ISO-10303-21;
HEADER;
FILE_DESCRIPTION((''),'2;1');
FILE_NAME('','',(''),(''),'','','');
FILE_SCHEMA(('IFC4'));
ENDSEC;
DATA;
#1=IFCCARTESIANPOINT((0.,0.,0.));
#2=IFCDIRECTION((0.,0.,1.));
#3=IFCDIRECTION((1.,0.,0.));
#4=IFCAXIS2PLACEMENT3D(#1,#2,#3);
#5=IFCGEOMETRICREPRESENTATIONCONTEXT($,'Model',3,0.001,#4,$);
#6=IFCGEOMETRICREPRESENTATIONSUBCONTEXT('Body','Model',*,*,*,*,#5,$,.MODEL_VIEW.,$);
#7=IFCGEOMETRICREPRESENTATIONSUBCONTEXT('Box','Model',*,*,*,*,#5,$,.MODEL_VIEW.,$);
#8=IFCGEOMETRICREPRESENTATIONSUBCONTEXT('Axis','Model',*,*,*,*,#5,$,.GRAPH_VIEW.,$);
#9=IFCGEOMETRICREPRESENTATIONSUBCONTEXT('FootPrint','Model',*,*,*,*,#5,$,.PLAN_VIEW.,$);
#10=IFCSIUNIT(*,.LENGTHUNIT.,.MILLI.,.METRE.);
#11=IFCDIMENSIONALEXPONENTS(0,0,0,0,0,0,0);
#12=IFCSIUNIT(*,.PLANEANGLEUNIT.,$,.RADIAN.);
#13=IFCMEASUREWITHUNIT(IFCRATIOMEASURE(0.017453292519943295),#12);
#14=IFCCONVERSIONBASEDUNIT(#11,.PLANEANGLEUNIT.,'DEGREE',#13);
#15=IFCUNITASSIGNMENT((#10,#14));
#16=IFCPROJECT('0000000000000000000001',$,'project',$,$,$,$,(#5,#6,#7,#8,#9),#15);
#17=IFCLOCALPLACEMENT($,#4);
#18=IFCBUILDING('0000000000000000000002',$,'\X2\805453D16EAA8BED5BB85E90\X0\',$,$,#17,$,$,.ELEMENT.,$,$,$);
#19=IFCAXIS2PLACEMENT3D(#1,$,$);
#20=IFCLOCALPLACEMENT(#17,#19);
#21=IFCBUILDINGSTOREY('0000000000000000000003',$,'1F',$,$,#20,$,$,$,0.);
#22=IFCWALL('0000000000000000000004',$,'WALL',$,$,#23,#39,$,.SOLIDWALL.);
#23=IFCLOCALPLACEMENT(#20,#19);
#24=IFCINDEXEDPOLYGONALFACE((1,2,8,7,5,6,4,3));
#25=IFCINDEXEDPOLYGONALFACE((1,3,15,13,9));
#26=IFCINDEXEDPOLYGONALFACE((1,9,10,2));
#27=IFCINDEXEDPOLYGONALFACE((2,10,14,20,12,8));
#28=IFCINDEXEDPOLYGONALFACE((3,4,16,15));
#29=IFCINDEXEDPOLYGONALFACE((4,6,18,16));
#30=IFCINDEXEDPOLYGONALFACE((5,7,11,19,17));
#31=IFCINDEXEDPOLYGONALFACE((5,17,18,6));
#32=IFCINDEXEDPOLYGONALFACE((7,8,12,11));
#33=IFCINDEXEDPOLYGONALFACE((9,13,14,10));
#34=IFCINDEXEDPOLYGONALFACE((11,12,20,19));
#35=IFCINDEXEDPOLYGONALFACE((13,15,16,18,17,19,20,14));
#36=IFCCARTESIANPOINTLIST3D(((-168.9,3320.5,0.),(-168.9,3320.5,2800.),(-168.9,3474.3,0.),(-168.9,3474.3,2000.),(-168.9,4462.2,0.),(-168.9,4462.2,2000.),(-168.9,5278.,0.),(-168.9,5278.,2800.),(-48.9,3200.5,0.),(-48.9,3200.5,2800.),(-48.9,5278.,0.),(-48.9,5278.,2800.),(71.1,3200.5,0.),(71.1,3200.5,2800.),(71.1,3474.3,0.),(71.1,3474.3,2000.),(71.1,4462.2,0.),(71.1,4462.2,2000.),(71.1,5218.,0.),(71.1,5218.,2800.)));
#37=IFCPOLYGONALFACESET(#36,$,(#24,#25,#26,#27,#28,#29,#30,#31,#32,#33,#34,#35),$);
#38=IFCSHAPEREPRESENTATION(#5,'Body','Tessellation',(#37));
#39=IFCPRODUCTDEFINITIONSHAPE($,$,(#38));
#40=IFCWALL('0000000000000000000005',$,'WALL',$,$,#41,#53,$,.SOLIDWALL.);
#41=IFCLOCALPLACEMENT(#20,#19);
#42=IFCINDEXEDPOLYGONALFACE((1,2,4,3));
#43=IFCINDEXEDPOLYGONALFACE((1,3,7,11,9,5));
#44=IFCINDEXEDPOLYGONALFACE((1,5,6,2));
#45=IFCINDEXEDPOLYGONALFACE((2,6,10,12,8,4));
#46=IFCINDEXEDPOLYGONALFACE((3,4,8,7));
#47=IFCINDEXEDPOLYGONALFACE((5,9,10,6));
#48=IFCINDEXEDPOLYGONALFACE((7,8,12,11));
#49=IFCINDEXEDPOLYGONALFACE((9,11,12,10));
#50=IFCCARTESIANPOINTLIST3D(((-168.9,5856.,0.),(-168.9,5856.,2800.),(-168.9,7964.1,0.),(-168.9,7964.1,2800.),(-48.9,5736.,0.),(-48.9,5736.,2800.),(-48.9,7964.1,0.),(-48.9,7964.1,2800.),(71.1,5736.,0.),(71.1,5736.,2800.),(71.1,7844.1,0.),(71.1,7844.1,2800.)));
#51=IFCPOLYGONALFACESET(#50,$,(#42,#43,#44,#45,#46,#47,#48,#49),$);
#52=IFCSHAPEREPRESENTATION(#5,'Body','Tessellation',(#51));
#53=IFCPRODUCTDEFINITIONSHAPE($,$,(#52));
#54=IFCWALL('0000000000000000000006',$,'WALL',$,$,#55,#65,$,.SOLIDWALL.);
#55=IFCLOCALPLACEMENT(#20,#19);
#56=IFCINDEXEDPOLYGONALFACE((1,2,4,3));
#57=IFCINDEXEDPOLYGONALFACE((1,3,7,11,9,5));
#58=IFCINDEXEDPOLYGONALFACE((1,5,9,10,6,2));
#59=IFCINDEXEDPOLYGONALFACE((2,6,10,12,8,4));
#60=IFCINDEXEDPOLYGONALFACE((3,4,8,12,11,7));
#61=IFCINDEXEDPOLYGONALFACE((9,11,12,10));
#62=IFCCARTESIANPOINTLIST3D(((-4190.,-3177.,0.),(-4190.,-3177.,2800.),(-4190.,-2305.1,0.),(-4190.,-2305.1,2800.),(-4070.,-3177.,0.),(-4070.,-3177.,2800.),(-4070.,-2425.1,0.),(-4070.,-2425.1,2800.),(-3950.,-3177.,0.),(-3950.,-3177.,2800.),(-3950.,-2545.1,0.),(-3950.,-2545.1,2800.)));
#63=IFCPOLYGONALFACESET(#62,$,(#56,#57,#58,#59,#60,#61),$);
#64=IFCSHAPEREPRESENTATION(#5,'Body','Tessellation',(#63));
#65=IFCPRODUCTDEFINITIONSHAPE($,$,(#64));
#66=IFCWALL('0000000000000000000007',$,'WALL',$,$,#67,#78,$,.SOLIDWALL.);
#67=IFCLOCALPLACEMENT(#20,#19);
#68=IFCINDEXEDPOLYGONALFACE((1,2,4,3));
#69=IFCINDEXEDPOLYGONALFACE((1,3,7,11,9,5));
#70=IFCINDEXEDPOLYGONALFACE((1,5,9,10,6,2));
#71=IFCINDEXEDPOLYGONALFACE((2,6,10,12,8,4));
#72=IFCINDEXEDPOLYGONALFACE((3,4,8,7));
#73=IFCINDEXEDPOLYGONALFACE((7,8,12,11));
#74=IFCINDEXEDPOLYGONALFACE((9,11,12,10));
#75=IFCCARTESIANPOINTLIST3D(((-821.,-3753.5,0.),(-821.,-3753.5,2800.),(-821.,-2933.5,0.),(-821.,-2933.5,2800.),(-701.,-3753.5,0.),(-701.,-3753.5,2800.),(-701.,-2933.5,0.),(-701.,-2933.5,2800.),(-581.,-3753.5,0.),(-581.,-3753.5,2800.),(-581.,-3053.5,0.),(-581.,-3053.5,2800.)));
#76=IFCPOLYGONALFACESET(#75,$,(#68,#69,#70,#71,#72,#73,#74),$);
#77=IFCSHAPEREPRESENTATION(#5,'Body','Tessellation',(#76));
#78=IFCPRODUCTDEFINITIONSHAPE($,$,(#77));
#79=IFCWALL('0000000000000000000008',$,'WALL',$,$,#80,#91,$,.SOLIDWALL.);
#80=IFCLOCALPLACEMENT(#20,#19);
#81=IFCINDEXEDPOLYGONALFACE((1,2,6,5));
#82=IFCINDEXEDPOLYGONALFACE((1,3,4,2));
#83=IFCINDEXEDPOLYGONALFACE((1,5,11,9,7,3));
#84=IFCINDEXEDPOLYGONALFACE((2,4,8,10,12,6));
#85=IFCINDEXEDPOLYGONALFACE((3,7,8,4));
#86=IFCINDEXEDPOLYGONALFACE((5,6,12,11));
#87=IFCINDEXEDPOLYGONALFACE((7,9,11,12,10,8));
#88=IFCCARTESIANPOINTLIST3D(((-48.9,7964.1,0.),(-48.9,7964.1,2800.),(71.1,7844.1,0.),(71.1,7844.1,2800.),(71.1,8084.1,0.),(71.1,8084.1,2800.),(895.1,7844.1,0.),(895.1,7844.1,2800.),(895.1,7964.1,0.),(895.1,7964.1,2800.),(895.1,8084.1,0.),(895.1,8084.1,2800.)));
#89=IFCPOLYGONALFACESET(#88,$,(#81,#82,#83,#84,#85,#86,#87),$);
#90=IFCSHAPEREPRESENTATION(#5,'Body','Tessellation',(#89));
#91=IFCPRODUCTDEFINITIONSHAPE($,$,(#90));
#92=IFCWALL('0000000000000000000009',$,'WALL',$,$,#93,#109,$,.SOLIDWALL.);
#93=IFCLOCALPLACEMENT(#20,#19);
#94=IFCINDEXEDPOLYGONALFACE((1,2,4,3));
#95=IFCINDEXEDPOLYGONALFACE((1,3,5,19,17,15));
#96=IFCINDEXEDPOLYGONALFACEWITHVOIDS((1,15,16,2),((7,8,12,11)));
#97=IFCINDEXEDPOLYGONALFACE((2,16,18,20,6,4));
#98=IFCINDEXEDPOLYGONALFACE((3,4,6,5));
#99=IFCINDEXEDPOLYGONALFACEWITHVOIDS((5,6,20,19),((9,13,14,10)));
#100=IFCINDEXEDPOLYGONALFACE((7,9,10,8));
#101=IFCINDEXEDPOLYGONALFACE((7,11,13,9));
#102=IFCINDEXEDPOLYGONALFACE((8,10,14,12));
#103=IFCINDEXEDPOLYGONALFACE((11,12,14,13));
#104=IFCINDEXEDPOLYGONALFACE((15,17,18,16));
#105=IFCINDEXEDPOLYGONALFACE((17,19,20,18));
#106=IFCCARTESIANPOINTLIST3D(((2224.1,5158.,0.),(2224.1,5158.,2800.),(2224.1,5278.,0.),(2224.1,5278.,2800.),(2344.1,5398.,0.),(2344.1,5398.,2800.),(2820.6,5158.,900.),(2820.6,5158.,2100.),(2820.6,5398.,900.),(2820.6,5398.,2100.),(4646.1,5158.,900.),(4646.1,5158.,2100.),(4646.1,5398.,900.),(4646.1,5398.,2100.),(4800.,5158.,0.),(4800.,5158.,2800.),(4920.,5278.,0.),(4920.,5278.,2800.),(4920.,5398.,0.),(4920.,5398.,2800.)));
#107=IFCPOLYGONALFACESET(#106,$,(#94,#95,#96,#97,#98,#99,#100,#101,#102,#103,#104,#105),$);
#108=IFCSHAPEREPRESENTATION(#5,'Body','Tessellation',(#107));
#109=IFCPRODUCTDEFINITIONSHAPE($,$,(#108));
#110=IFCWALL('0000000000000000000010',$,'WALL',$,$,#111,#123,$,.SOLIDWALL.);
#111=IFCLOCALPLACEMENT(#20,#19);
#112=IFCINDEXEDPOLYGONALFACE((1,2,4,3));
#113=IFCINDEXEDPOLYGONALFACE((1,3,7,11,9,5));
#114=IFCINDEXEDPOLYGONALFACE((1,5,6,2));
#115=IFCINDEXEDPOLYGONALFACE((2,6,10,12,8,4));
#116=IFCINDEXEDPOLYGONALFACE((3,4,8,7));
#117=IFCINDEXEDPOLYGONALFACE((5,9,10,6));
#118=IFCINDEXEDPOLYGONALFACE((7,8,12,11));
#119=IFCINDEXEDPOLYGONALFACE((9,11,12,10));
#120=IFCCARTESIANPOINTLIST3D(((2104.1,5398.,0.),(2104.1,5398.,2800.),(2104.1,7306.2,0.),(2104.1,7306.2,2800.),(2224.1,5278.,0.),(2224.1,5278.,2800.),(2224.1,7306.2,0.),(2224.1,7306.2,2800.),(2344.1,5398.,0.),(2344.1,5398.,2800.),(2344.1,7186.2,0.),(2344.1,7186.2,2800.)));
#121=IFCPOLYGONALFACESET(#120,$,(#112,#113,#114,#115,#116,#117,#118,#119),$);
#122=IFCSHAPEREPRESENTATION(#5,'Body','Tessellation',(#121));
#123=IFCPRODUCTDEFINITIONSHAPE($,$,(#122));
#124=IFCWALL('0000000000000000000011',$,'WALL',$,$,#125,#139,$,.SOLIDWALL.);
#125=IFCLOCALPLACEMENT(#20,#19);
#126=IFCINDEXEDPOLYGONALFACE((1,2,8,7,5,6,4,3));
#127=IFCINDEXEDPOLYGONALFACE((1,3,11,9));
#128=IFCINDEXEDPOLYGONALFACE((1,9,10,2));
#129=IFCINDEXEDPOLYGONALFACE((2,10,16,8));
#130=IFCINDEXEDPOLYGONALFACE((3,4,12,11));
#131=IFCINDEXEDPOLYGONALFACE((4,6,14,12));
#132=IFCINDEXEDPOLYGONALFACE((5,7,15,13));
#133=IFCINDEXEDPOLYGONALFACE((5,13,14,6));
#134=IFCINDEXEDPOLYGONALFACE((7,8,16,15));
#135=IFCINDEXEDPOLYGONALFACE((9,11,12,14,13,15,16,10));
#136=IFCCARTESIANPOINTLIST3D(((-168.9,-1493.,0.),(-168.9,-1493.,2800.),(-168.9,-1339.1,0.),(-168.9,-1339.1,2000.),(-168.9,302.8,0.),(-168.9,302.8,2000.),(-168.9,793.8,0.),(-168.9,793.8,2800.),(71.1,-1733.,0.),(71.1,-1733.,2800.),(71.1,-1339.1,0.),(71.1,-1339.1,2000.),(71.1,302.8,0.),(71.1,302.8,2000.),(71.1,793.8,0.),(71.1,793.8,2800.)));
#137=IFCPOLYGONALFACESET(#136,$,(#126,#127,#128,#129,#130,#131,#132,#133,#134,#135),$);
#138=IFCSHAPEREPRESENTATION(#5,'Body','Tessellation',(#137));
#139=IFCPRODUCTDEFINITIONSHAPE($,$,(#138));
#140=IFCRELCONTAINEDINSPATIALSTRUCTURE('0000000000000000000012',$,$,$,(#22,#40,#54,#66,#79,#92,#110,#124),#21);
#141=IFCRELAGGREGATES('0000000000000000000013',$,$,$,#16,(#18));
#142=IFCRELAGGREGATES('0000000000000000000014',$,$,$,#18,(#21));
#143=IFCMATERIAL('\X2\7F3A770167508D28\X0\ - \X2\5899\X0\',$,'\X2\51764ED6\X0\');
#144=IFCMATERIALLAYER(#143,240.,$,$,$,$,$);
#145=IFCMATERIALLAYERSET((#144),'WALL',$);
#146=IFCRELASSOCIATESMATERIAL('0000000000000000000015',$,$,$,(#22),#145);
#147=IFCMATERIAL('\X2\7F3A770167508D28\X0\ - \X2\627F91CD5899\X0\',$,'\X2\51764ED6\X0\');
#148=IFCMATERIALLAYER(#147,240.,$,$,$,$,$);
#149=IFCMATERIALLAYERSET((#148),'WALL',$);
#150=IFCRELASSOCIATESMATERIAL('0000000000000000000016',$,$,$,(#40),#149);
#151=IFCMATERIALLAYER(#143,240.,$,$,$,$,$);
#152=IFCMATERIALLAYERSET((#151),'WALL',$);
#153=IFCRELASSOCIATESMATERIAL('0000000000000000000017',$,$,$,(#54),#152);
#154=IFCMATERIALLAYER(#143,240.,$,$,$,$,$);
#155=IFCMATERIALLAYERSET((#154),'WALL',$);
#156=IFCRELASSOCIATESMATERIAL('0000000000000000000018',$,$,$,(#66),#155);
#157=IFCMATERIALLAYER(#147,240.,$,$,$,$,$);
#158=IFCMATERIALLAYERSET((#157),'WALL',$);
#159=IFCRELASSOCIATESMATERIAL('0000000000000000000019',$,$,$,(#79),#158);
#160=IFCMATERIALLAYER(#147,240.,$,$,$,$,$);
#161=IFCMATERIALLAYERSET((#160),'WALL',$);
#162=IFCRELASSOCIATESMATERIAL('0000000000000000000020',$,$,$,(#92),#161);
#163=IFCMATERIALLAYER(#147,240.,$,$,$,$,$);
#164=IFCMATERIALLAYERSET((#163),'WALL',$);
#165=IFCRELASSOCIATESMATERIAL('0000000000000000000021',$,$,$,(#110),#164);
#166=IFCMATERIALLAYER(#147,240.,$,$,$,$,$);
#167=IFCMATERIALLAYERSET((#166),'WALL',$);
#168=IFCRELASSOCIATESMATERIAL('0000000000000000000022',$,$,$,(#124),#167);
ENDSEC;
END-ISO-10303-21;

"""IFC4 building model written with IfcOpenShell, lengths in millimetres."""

from ifc_helpers import new_model, entity, si_unit, converted_unit, frame, origin, origin_with_axes, place, context, subcontext, project, spatial, polyline, segment, composite_curve, outline, extrude, material, layer, layer_set, layer_usage, element, save


model = new_model("IFC4")

# Units and contexts
model_context = context("Model", 3, precision=0.001, world=origin_with_axes())
body_context = subcontext(model_context, "Body", "Model", "MODEL_VIEW")
box_context = subcontext(model_context, "Box", "Model", "MODEL_VIEW")
axis_context = subcontext(model_context, "Axis", "Model", "GRAPH_VIEW")
footprint_context = subcontext(model_context, "FootPrint", "Model", "PLAN_VIEW")
ifc_project = project(units=[si_unit("LENGTHUNIT", "METRE", prefix="MILLI"), converted_unit("PLANEANGLEUNIT", "DEGREE", entity("IfcRatioMeasure", 0.017453292519943295), si_unit("PLANEANGLEUNIT", "RADIAN"), dimensions=[0, 0, 0, 0, 0, 0, 0])], contexts=[model_context, body_context, box_context, axis_context, footprint_context])

# Building, storey
building_placement = place(None, origin_with_axes())
building = spatial("IfcBuilding", under=ifc_project, at=building_placement, Name="联发溪语宸庐", CompositionType="ELEMENT")
storey_placement = place(building_placement, origin())
storey = spatial("IfcBuildingStorey", under=building, at=storey_placement, Name="1F", Elevation=0.0)

# Shared definitions
ifc_material_1 = material(Name="缺省材质 - 墙", Category="其他")

# Shared definitions
ifc_material_2 = material(Name="缺省材质 - 承重墙", Category="其他")

# Wall, opening
ifc_layer_1 = layer(ifc_material_1, 240.0)
ifc_layer_set_1 = layer_set([ifc_layer_1], Name="WALL")
ifc_layer_usage_1 = layer_usage(ifc_layer_set_1, "AXIS2", "NEGATIVE", 120.0)
wall_1_placement = place(None, origin_with_axes())
wall_1 = element("IfcWall", 1, at=wall_1_placement, inside=storey, material=ifc_layer_usage_1, Name="WALL", PredefinedType="SOLIDWALL", context=model_context, shape_type="SweptSolid", body=[
    extrude(outline(composite_curve([segment(polyline([(-48.9, 3200.5), (71.1, 3200.5)]), True, "CONTINUOUS"), segment(polyline([(71.1, 3200.5), (71.1, 5218.0)]), True, "CONTINUOUS"), segment(polyline([(71.1, 5218.0), (-48.9, 5278.0)]), True, "CONTINUOUS"), segment(polyline([(-48.9, 5278.0), (-168.9, 5278.0)]), True, "CONTINUOUS"), segment(polyline([(-168.9, 5278.0), (-168.9, 3320.5)]), True, "CONTINUOUS"), segment(polyline([(-168.9, 3320.5), (-48.9, 3200.5)]), True, "CONTINUOUS")], self_intersect=False)), origin(), (0.0, 0.0, 1.0), 2800.0),
])
opening_1_placement = place(None, origin_with_axes())
element("IfcOpeningElement", 2, at=opening_1_placement, cuts=wall_1, ObjectType="OPENING", PredefinedType="OPENING", context=model_context, shape_type="SweptSolid", body=[
    extrude(outline(composite_curve([segment(polyline([(-168.9, 4462.2), (-168.9, 3474.3)]), True, "CONTINUOUS"), segment(polyline([(-168.9, 3474.3), (71.1, 3474.3)]), True, "CONTINUOUS"), segment(polyline([(71.1, 3474.3), (71.1, 4462.2)]), True, "CONTINUOUS"), segment(polyline([(71.1, 4462.2), (-168.9, 4462.2)]), True, "CONTINUOUS")], self_intersect=False)), origin_with_axes(), (0.0, 0.0, 1.0), 2000.0),
])

# Walls
ifc_layer_2 = layer(ifc_material_2, 240.0)
ifc_layer_set_2 = layer_set([ifc_layer_2], Name="WALL")
ifc_layer_usage_2 = layer_usage(ifc_layer_set_2, "AXIS2", "NEGATIVE", 120.0)
wall_2_placement = place(None, origin_with_axes())
element("IfcWall", 3, at=wall_2_placement, inside=storey, material=ifc_layer_usage_2, Name="WALL", PredefinedType="SOLIDWALL", context=model_context, shape_type="SweptSolid", body=[
    extrude(outline(composite_curve([segment(polyline([(-48.9, 5736.0), (71.1, 5736.0)]), True, "CONTINUOUS"), segment(polyline([(71.1, 5736.0), (71.1, 7844.1)]), True, "CONTINUOUS"), segment(polyline([(71.1, 7844.1), (-48.9, 7964.1)]), True, "CONTINUOUS"), segment(polyline([(-48.9, 7964.1), (-168.9, 7964.1)]), True, "CONTINUOUS"), segment(polyline([(-168.9, 7964.1), (-168.9, 5856.0)]), True, "CONTINUOUS"), segment(polyline([(-168.9, 5856.0), (-48.9, 5736.0)]), True, "CONTINUOUS")], self_intersect=False)), origin(), (0.0, 0.0, 1.0), 2800.0),
])
ifc_layer_3 = layer(ifc_material_1, 240.0)
ifc_layer_set_3 = layer_set([ifc_layer_3], Name="WALL")
ifc_layer_usage_3 = layer_usage(ifc_layer_set_3, "AXIS2", "NEGATIVE", 120.0)
wall_3_placement = place(None, origin_with_axes())
element("IfcWall", 4, at=wall_3_placement, inside=storey, material=ifc_layer_usage_3, Name="WALL", PredefinedType="SOLIDWALL", context=model_context, shape_type="SweptSolid", body=[
    extrude(outline(composite_curve([segment(polyline([(-4070.0, -2425.1), (-4190.0, -2305.1)]), True, "CONTINUOUS"), segment(polyline([(-4190.0, -2305.1), (-4190.0, -3177.0)]), True, "CONTINUOUS"), segment(polyline([(-4190.0, -3177.0), (-4070.0, -3177.0)]), True, "CONTINUOUS"), segment(polyline([(-4070.0, -3177.0), (-3950.0, -3177.0)]), True, "CONTINUOUS"), segment(polyline([(-3950.0, -3177.0), (-3950.0, -2545.1)]), True, "CONTINUOUS"), segment(polyline([(-3950.0, -2545.1), (-4070.0, -2425.1)]), True, "CONTINUOUS")], self_intersect=False)), origin(), (0.0, 0.0, 1.0), 2800.0),
])
ifc_layer_4 = layer(ifc_material_1, 240.0)
ifc_layer_set_4 = layer_set([ifc_layer_4], Name="WALL")
ifc_layer_usage_4 = layer_usage(ifc_layer_set_4, "AXIS2", "NEGATIVE", 120.0)
wall_4_placement = place(None, origin_with_axes())
element("IfcWall", 5, at=wall_4_placement, inside=storey, material=ifc_layer_usage_4, Name="WALL", PredefinedType="SOLIDWALL", context=model_context, shape_type="SweptSolid", body=[
    extrude(outline(composite_curve([segment(polyline([(-701.0, -3753.5), (-581.0, -3753.5)]), True, "CONTINUOUS"), segment(polyline([(-581.0, -3753.5), (-581.0, -3053.5)]), True, "CONTINUOUS"), segment(polyline([(-581.0, -3053.5), (-701.0, -2933.5)]), True, "CONTINUOUS"), segment(polyline([(-701.0, -2933.5), (-821.0, -2933.5)]), True, "CONTINUOUS"), segment(polyline([(-821.0, -2933.5), (-821.0, -3753.5)]), True, "CONTINUOUS"), segment(polyline([(-821.0, -3753.5), (-701.0, -3753.5)]), True, "CONTINUOUS")], self_intersect=False)), origin(), (0.0, 0.0, 1.0), 2800.0),
])
ifc_layer_5 = layer(ifc_material_2, 240.0)
ifc_layer_set_5 = layer_set([ifc_layer_5], Name="WALL")
ifc_layer_usage_5 = layer_usage(ifc_layer_set_5, "AXIS2", "NEGATIVE", 120.0)
wall_5_placement = place(None, origin_with_axes())
element("IfcWall", 6, at=wall_5_placement, inside=storey, material=ifc_layer_usage_5, Name="WALL", PredefinedType="SOLIDWALL", context=model_context, shape_type="SweptSolid", body=[
    extrude(outline(composite_curve([segment(polyline([(-48.9, 7964.1), (71.1, 7844.1)]), True, "CONTINUOUS"), segment(polyline([(71.1, 7844.1), (895.1, 7844.1)]), True, "CONTINUOUS"), segment(polyline([(895.1, 7844.1), (895.1, 7964.1)]), True, "CONTINUOUS"), segment(polyline([(895.1, 7964.1), (895.1, 8084.1)]), True, "CONTINUOUS"), segment(polyline([(895.1, 8084.1), (71.1, 8084.1)]), True, "CONTINUOUS"), segment(polyline([(71.1, 8084.1), (-48.9, 7964.1)]), True, "CONTINUOUS")], self_intersect=False)), origin(), (0.0, 0.0, 1.0), 2800.0),
])

# Wall, opening
ifc_layer_6 = layer(ifc_material_2, 240.0)
ifc_layer_set_6 = layer_set([ifc_layer_6], Name="WALL")
ifc_layer_usage_6 = layer_usage(ifc_layer_set_6, "AXIS2", "NEGATIVE", 120.0)
wall_6_placement = place(None, origin_with_axes())
wall_6 = element("IfcWall", 7, at=wall_6_placement, inside=storey, material=ifc_layer_usage_6, Name="WALL", PredefinedType="SOLIDWALL", context=model_context, shape_type="SweptSolid", body=[
    extrude(outline(composite_curve([segment(polyline([(2224.1, 5278.0), (2224.1, 5158.0)]), True, "CONTINUOUS"), segment(polyline([(2224.1, 5158.0), (4800.0, 5158.0)]), True, "CONTINUOUS"), segment(polyline([(4800.0, 5158.0), (4920.0, 5278.0)]), True, "CONTINUOUS"), segment(polyline([(4920.0, 5278.0), (4920.0, 5398.0)]), True, "CONTINUOUS"), segment(polyline([(4920.0, 5398.0), (2344.1, 5398.0)]), True, "CONTINUOUS"), segment(polyline([(2344.1, 5398.0), (2224.1, 5278.0)]), True, "CONTINUOUS")], self_intersect=False)), origin(), (0.0, 0.0, 1.0), 2800.0),
])
opening_2_placement = place(None, origin_with_axes())
element("IfcOpeningElement", 8, at=opening_2_placement, cuts=wall_6, ObjectType="OPENING", PredefinedType="OPENING", context=model_context, shape_type="SweptSolid", body=[
    extrude(outline(composite_curve([segment(polyline([(4646.1, 5398.0), (2820.6, 5398.0)]), True, "CONTINUOUS"), segment(polyline([(2820.6, 5398.0), (2820.6, 5158.0)]), True, "CONTINUOUS"), segment(polyline([(2820.6, 5158.0), (4646.1, 5158.0)]), True, "CONTINUOUS"), segment(polyline([(4646.1, 5158.0), (4646.1, 5398.0)]), True, "CONTINUOUS")], self_intersect=False)), frame((0.0, 0.0, 900.0), z_axis=(0.0, 0.0, 1.0), x_axis=(1.0, 0.0, 0.0)), (0.0, 0.0, 1.0), 1200.0),
])

# Wall
ifc_layer_7 = layer(ifc_material_2, 240.0)
ifc_layer_set_7 = layer_set([ifc_layer_7], Name="WALL")
ifc_layer_usage_7 = layer_usage(ifc_layer_set_7, "AXIS2", "NEGATIVE", 120.0)
wall_7_placement = place(None, origin_with_axes())
element("IfcWall", 9, at=wall_7_placement, inside=storey, material=ifc_layer_usage_7, Name="WALL", PredefinedType="SOLIDWALL", context=model_context, shape_type="SweptSolid", body=[
    extrude(outline(composite_curve([segment(polyline([(2224.1, 7306.2), (2104.1, 7306.2)]), True, "CONTINUOUS"), segment(polyline([(2104.1, 7306.2), (2104.1, 5398.0)]), True, "CONTINUOUS"), segment(polyline([(2104.1, 5398.0), (2224.1, 5278.0)]), True, "CONTINUOUS"), segment(polyline([(2224.1, 5278.0), (2344.1, 5398.0)]), True, "CONTINUOUS"), segment(polyline([(2344.1, 5398.0), (2344.1, 7186.2)]), True, "CONTINUOUS"), segment(polyline([(2344.1, 7186.2), (2224.1, 7306.2)]), True, "CONTINUOUS")], self_intersect=False)), origin(), (0.0, 0.0, 1.0), 2800.0),
])

# Wall, opening
ifc_layer_8 = layer(ifc_material_2, 240.0)
ifc_layer_set_8 = layer_set([ifc_layer_8], Name="WALL")
ifc_layer_usage_8 = layer_usage(ifc_layer_set_8, "AXIS2", "NEGATIVE", 120.0)
wall_8_placement = place(None, origin_with_axes())
wall_8 = element("IfcWall", 10, at=wall_8_placement, inside=storey, material=ifc_layer_usage_8, Name="WALL", PredefinedType="SOLIDWALL", context=model_context, shape_type="SweptSolid", body=[
    extrude(outline(composite_curve([segment(polyline([(-48.9, -1613.0), (71.1, -1733.0)]), True, "CONTINUOUS"), segment(polyline([(71.1, -1733.0), (71.1, 793.8)]), True, "CONTINUOUS"), segment(polyline([(71.1, 793.8), (-48.9, 793.8)]), True, "CONTINUOUS"), segment(polyline([(-48.9, 793.8), (-168.9, 793.8)]), True, "CONTINUOUS"), segment(polyline([(-168.9, 793.8), (-168.9, -1493.0)]), True, "CONTINUOUS"), segment(polyline([(-168.9, -1493.0), (-48.9, -1613.0)]), True, "CONTINUOUS")], self_intersect=False)), origin(), (0.0, 0.0, 1.0), 2800.0),
])
opening_3_placement = place(None, origin_with_axes())
element("IfcOpeningElement", 11, at=opening_3_placement, cuts=wall_8, ObjectType="OPENING", PredefinedType="OPENING", context=model_context, shape_type="SweptSolid", body=[
    extrude(outline(composite_curve([segment(polyline([(-168.9, 302.8), (-168.9, -1339.1)]), True, "CONTINUOUS"), segment(polyline([(-168.9, -1339.1), (71.1, -1339.1)]), True, "CONTINUOUS"), segment(polyline([(71.1, -1339.1), (71.1, 302.8)]), True, "CONTINUOUS"), segment(polyline([(71.1, 302.8), (-168.9, 302.8)]), True, "CONTINUOUS")], self_intersect=False)), origin_with_axes(), (0.0, 0.0, 1.0), 2000.0),
])

save(model, "model.ifc")
